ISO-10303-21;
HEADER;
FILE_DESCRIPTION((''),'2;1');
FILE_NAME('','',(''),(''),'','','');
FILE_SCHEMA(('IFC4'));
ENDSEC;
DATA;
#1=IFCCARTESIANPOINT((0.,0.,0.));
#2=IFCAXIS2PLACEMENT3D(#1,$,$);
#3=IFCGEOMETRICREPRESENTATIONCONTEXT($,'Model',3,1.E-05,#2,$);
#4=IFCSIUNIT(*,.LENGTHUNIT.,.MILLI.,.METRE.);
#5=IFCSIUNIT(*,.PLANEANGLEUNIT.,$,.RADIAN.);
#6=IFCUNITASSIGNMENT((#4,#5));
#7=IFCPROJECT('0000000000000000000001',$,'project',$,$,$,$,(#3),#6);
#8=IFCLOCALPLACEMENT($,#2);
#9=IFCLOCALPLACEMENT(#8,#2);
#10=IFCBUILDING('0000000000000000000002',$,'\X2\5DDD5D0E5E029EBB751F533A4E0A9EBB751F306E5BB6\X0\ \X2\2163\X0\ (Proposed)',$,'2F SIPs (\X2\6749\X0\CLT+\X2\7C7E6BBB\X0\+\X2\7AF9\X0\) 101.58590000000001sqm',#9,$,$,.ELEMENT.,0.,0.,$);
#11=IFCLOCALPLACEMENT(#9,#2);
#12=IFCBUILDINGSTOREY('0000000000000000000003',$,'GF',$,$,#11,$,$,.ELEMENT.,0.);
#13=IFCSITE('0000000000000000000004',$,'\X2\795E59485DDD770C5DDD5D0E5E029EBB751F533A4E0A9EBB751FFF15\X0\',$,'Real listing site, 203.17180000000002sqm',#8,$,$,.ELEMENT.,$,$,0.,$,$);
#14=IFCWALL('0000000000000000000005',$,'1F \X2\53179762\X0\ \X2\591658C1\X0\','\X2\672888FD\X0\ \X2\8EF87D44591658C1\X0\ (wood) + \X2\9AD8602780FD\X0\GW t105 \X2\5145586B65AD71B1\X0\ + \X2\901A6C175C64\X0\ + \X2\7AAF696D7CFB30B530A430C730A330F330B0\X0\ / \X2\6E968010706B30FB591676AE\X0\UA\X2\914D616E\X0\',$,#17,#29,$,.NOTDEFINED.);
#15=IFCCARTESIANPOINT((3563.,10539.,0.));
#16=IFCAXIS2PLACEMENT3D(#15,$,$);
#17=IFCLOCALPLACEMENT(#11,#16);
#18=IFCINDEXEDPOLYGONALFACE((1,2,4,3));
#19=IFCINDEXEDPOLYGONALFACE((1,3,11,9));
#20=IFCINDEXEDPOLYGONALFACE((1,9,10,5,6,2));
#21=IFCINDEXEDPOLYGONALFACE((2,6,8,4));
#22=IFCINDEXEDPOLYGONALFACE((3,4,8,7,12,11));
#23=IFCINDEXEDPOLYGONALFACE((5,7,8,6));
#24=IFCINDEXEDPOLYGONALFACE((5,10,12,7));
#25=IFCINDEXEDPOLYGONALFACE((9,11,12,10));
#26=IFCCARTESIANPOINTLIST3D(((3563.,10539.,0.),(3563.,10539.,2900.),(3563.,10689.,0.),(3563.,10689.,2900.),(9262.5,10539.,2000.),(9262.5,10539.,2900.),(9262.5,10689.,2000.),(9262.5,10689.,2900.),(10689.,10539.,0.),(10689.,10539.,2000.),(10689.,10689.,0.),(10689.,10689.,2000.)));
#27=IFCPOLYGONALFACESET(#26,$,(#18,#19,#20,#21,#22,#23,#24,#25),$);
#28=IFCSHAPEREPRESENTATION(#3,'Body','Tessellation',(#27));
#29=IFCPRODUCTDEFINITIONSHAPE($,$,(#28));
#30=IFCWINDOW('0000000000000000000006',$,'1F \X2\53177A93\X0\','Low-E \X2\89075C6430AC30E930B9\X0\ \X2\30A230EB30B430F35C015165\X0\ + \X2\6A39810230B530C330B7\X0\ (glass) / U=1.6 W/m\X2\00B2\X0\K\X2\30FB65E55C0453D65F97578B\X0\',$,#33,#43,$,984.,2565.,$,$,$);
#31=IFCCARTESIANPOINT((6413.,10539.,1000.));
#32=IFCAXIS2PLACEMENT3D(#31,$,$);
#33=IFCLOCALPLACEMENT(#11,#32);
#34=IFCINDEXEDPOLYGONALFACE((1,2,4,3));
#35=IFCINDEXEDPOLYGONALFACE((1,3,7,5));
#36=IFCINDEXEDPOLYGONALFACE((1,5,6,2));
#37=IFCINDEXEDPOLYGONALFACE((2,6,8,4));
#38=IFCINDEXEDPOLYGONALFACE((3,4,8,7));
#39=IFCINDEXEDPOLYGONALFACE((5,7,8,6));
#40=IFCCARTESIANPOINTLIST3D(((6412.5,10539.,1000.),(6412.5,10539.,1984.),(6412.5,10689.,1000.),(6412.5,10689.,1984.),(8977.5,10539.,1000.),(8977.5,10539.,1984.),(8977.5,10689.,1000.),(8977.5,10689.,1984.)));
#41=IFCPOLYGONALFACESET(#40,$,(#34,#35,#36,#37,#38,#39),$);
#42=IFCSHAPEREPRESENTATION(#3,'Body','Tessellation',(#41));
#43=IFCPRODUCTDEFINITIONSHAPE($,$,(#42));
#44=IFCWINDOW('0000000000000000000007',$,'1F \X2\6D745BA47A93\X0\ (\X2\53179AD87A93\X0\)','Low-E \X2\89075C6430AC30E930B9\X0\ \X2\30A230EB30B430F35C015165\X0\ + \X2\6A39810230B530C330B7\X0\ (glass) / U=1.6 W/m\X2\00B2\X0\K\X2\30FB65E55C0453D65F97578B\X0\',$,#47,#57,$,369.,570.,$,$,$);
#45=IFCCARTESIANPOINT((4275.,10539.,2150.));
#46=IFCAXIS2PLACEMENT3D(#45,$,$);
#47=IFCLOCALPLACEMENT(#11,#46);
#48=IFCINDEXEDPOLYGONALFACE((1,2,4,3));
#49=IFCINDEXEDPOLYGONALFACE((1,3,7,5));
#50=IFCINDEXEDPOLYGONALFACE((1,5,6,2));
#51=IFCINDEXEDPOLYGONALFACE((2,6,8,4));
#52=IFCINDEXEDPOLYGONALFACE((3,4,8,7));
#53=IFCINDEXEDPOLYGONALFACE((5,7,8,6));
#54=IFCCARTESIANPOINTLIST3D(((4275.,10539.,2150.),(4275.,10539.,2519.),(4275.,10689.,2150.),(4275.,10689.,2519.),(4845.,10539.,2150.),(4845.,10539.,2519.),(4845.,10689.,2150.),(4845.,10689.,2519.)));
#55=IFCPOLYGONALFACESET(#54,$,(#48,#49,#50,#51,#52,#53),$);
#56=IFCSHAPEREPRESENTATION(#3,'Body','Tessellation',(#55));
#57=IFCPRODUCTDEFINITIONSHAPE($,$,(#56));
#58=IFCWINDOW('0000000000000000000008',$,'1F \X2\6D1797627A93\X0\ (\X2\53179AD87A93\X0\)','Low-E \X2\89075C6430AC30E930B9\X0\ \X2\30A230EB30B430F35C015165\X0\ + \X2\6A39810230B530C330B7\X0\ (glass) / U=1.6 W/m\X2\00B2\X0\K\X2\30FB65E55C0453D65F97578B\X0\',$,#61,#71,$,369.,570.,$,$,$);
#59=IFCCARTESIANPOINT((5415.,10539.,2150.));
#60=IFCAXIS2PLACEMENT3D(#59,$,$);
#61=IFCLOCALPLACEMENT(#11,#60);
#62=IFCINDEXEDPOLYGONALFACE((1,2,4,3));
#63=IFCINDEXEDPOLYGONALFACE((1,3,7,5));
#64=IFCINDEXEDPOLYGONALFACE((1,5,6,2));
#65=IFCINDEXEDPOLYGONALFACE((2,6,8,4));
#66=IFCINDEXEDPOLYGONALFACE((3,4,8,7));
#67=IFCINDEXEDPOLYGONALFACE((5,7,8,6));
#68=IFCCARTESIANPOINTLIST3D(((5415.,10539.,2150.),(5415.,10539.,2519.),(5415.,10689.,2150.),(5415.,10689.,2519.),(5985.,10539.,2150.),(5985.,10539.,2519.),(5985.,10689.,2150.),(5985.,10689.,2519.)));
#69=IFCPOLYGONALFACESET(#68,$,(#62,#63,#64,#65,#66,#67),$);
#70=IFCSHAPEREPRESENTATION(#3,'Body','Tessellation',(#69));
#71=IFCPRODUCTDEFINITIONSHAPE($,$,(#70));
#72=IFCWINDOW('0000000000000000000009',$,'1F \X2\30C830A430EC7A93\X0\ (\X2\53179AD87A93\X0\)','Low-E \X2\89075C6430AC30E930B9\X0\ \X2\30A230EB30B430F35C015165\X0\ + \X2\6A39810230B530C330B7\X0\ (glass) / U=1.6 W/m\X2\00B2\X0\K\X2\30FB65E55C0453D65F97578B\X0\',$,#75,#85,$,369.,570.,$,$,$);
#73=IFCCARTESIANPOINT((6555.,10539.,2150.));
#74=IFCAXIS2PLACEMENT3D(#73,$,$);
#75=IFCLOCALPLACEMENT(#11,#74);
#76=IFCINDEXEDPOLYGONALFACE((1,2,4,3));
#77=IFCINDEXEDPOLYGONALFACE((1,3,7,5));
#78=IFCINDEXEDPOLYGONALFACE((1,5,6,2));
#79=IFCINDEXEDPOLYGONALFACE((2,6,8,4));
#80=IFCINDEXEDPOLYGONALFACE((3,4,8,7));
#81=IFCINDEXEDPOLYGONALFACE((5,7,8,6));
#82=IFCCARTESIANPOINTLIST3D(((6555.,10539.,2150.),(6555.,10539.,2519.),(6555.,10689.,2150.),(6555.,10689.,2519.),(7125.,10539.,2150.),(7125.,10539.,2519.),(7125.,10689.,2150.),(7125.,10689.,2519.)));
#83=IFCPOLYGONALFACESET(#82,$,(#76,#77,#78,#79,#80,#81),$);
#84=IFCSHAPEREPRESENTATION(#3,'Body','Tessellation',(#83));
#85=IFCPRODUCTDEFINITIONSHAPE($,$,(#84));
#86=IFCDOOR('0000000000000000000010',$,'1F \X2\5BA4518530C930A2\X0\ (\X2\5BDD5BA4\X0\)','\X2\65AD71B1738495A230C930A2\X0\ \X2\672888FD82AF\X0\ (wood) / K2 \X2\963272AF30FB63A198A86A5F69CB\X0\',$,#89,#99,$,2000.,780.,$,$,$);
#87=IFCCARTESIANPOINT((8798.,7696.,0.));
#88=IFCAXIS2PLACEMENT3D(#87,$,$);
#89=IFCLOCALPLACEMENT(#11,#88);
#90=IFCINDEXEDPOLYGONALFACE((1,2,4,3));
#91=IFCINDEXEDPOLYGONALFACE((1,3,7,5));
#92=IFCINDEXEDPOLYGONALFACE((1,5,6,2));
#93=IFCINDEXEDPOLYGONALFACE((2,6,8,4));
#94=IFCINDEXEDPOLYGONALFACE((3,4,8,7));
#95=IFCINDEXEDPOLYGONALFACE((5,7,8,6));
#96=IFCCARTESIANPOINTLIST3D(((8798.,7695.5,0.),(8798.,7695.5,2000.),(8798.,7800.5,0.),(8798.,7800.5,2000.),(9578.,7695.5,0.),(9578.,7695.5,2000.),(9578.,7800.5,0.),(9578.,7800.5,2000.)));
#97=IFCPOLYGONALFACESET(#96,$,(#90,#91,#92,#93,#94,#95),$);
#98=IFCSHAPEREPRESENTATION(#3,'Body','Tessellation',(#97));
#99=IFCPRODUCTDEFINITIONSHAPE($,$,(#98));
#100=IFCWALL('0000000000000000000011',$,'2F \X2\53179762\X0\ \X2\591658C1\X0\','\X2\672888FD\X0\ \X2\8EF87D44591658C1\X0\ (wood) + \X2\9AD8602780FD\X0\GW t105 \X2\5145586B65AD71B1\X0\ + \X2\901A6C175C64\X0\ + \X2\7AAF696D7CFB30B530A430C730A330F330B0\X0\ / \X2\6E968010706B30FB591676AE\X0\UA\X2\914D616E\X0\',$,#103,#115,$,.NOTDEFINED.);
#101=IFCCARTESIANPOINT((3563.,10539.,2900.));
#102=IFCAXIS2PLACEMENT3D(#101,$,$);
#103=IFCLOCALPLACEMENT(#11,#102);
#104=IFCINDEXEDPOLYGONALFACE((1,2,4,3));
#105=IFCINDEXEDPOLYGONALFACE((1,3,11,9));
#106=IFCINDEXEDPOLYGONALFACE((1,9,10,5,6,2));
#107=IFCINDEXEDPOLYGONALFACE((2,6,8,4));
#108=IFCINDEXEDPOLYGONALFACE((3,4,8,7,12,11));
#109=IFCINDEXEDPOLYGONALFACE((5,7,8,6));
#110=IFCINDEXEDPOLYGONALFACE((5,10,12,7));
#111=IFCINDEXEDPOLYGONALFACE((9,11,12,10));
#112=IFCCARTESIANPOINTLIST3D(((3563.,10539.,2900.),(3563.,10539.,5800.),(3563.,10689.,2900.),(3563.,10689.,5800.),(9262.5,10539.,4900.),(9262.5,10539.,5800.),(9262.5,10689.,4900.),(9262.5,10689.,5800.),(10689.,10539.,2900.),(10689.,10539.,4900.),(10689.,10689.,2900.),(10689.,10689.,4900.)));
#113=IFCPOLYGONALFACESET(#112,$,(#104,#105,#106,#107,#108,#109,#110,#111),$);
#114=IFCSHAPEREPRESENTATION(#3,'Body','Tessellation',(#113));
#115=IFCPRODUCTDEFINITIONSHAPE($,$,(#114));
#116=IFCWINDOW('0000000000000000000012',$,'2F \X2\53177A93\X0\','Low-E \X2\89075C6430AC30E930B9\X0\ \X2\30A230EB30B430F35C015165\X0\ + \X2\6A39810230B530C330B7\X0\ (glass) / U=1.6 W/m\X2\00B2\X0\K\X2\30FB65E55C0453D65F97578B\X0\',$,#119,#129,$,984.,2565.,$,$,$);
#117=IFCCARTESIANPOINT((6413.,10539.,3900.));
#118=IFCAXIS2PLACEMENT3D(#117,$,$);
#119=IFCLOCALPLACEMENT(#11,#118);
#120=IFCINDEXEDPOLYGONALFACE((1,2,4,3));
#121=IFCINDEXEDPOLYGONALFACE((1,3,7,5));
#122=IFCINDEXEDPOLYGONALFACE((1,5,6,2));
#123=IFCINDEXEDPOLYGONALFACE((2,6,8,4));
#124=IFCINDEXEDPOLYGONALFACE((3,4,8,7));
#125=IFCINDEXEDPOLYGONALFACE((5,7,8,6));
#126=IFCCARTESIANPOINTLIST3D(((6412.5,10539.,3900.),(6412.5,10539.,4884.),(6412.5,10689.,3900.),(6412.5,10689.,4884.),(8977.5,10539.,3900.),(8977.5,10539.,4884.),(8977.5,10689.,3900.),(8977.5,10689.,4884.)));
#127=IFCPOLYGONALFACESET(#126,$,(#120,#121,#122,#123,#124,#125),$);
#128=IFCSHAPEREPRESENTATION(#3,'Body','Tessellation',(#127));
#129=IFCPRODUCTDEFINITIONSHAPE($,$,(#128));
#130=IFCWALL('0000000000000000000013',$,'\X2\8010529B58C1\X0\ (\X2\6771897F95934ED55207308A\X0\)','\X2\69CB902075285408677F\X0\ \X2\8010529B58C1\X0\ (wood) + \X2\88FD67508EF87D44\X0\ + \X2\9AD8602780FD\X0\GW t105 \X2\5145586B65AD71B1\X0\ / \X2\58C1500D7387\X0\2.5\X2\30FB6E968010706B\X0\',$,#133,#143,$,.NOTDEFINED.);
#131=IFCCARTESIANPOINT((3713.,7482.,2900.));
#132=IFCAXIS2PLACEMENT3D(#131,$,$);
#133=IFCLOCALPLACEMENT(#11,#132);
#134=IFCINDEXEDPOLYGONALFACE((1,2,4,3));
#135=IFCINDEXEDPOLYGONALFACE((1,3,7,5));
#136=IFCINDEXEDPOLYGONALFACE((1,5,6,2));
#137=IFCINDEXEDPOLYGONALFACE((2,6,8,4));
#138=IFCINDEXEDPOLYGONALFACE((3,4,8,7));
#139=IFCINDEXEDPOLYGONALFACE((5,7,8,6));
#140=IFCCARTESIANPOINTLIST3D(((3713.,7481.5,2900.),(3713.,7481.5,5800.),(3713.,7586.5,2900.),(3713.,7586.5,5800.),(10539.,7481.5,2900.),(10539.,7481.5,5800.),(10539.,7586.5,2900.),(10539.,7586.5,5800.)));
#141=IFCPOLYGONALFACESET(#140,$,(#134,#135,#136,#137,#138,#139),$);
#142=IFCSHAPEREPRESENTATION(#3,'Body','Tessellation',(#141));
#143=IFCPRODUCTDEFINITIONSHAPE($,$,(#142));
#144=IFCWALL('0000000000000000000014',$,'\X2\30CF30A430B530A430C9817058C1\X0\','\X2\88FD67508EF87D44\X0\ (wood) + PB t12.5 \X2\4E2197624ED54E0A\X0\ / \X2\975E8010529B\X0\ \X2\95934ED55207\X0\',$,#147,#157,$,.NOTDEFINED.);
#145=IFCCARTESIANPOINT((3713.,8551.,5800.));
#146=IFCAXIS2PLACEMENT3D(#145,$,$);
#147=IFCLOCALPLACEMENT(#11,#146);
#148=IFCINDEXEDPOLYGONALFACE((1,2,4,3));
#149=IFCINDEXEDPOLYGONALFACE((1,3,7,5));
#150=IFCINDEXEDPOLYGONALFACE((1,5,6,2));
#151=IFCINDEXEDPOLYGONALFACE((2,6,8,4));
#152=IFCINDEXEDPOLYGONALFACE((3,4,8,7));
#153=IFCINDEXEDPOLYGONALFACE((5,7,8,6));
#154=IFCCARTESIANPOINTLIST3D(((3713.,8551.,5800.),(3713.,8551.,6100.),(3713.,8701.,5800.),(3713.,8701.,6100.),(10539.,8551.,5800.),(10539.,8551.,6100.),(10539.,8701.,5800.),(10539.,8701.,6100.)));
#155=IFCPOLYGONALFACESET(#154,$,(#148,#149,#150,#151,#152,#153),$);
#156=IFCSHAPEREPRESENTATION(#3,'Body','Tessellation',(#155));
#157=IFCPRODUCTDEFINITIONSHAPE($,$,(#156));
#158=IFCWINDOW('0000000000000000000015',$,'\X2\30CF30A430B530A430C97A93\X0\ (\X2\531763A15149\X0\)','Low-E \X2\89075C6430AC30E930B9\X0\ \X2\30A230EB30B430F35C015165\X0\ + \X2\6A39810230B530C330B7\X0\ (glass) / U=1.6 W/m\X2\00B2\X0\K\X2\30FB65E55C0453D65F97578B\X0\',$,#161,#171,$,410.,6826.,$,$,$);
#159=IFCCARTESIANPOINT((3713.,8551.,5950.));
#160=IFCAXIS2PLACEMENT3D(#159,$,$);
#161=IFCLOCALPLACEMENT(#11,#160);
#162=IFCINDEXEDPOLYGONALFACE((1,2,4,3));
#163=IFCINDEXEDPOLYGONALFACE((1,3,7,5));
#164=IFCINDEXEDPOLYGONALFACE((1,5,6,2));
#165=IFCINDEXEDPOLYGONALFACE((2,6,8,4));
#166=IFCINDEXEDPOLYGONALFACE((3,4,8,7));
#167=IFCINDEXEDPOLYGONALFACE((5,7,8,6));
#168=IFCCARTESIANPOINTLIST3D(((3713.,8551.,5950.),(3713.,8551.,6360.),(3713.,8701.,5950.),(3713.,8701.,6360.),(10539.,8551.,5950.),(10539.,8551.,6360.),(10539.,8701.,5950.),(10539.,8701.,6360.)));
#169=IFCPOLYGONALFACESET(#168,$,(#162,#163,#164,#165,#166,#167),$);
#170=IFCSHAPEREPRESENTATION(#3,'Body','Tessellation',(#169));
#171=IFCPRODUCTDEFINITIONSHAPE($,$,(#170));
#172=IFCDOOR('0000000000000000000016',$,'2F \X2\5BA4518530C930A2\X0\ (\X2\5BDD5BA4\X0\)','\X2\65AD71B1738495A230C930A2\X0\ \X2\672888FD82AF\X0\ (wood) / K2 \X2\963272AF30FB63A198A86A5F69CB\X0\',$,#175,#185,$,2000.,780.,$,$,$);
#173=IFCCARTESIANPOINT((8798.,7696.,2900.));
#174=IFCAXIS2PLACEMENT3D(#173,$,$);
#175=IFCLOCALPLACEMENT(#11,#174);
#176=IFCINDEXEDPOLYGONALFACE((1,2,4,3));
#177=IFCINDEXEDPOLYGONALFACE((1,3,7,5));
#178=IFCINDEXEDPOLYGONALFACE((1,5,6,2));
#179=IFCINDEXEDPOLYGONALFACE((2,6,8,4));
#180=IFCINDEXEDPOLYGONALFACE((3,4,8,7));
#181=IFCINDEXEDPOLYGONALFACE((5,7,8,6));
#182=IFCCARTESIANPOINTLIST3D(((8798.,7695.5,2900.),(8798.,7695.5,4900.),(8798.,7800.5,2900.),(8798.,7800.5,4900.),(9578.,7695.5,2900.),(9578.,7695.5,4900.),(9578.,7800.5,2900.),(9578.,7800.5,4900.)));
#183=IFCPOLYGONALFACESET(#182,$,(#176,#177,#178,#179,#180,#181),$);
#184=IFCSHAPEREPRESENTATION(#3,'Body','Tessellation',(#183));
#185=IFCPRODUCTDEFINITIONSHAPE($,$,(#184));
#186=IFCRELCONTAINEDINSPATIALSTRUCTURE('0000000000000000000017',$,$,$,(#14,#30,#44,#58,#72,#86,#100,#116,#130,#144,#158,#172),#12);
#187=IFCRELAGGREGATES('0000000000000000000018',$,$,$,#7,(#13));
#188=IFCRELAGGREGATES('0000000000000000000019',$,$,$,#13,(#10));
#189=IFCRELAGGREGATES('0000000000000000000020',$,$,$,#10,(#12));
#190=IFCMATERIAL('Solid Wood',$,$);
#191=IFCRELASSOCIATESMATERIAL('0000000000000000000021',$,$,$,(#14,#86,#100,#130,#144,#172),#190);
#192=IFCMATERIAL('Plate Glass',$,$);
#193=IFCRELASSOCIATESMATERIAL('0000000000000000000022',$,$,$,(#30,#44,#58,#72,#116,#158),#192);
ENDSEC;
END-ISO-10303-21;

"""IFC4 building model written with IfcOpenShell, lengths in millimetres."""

from ifc_helpers import new_model, si_unit, frame, frame_2d, origin, place, context, project, spatial, rectangle, extrude, material, element, fill, save


model = new_model("IFC4")

# Units and contexts
model_context = context("Model", 3, precision=1e-05, world=origin())
ifc_project = project(units=[si_unit("LENGTHUNIT", "METRE", prefix="MILLI"), si_unit("PLANEANGLEUNIT", "RADIAN")], contexts=[model_context])

# Site, building, storey
site_placement = place(None, origin())
site = spatial("IfcSite", under=ifc_project, at=site_placement, Name="神奈川県川崎市麻生区上麻生５", ObjectType="Real listing site, 203.17180000000002sqm", CompositionType="ELEMENT", RefElevation=0.0)
building_placement = place(site_placement, origin())
building = spatial("IfcBuilding", under=site, at=building_placement, Name="川崎市麻生区上麻生の家 Ⅳ (Proposed)", ObjectType="2F SIPs (杉CLT+籾殻+竹) 101.58590000000001sqm", CompositionType="ELEMENT", ElevationOfRefHeight=0.0, ElevationOfTerrain=0.0)
storey_placement = place(building_placement, origin())
storey = spatial("IfcBuildingStorey", under=building, at=storey_placement, Name="GF", CompositionType="ELEMENT", Elevation=0.0)

# Wall, openings, windows
ifc_material_1 = material(Name="Solid Wood")
wall_1_placement = place(storey_placement, frame((3563.0, 10539.0, 0.0)))
wall_1 = element("IfcWall", 1, at=wall_1_placement, inside=storey, material=ifc_material_1, Name="1F 北面 外壁", Description="木製 軸組外壁 (wood) + 高性能GW t105 充填断熱 + 通気層 + 窯業系サイディング / 準耐火・外皮UA配慮", PredefinedType="NOTDEFINED", context=model_context, shape_type="SweptSolid", body=[
    extrude(rectangle(XDim=7126.0, YDim=150.0, at=frame_2d((3563.0, 75.0))), frame((3563.0, 10539.0, 0.0)), (0.0, 0.0, 1.0), 2900.0),
])
opening_1_placement = place(storey_placement, frame((6413.0, 10539.0, 1000.0)))
opening_1 = element("IfcOpeningElement", 2, at=opening_1_placement, cuts=wall_1, PredefinedType="NOTDEFINED", context=model_context, shape_type="SweptSolid", body=[
    extrude(rectangle(XDim=2565.0, YDim=150.0, at=frame_2d((1282.0, 75.0))), frame((6413.0, 10539.0, 1000.0)), (0.0, 0.0, 1.0), 984.0),
])
opening_2_placement = place(storey_placement, frame((4275.0, 10539.0, 2150.0)))
opening_2 = element("IfcOpeningElement", 3, at=opening_2_placement, cuts=wall_1, PredefinedType="NOTDEFINED", context=model_context, shape_type="SweptSolid", body=[
    extrude(rectangle(XDim=570.0, YDim=150.0, at=frame_2d((285.0, 75.0))), frame((4275.0, 10539.0, 2150.0)), (0.0, 0.0, 1.0), 369.0),
])
opening_3_placement = place(storey_placement, frame((5415.0, 10539.0, 2150.0)))
opening_3 = element("IfcOpeningElement", 4, at=opening_3_placement, cuts=wall_1, PredefinedType="NOTDEFINED", context=model_context, shape_type="SweptSolid", body=[
    extrude(rectangle(XDim=570.0, YDim=150.0, at=frame_2d((285.0, 75.0))), frame((5415.0, 10539.0, 2150.0)), (0.0, 0.0, 1.0), 369.0),
])
opening_4_placement = place(storey_placement, frame((6555.0, 10539.0, 2150.0)))
opening_4 = element("IfcOpeningElement", 5, at=opening_4_placement, cuts=wall_1, PredefinedType="NOTDEFINED", context=model_context, shape_type="SweptSolid", body=[
    extrude(rectangle(XDim=570.0, YDim=150.0, at=frame_2d((285.0, 75.0))), frame((6555.0, 10539.0, 2150.0)), (0.0, 0.0, 1.0), 369.0),
])
ifc_material_2 = material(Name="Plate Glass")
window_1_placement = place(storey_placement, frame((6413.0, 10539.0, 1000.0)))
window_1 = element("IfcWindow", 6, at=window_1_placement, inside=storey, material=ifc_material_2, Name="1F 北窓", Description="Low-E 複層ガラス アルゴン封入 + 樹脂サッシ (glass) / U=1.6 W/m²K・日射取得型", OverallHeight=984.0, OverallWidth=2565.0, context=model_context, shape_type="SweptSolid", body=[
    extrude(rectangle(XDim=2565.0, YDim=150.0, at=frame_2d((1282.0, 75.0))), frame((6413.0, 10539.0, 1000.0)), (0.0, 0.0, 1.0), 984.0),
])
fill(opening_1, window_1)
window_2_placement = place(storey_placement, frame((4275.0, 10539.0, 2150.0)))
window_2 = element("IfcWindow", 7, at=window_2_placement, inside=storey, material=ifc_material_2, Name="1F 浴室窓 (北高窓)", Description="Low-E 複層ガラス アルゴン封入 + 樹脂サッシ (glass) / U=1.6 W/m²K・日射取得型", OverallHeight=369.0, OverallWidth=570.0, context=model_context, shape_type="SweptSolid", body=[
    extrude(rectangle(XDim=570.0, YDim=150.0, at=frame_2d((285.0, 75.0))), frame((4275.0, 10539.0, 2150.0)), (0.0, 0.0, 1.0), 369.0),
])
fill(opening_2, window_2)
window_3_placement = place(storey_placement, frame((5415.0, 10539.0, 2150.0)))
window_3 = element("IfcWindow", 8, at=window_3_placement, inside=storey, material=ifc_material_2, Name="1F 洗面窓 (北高窓)", Description="Low-E 複層ガラス アルゴン封入 + 樹脂サッシ (glass) / U=1.6 W/m²K・日射取得型", OverallHeight=369.0, OverallWidth=570.0, context=model_context, shape_type="SweptSolid", body=[
    extrude(rectangle(XDim=570.0, YDim=150.0, at=frame_2d((285.0, 75.0))), frame((5415.0, 10539.0, 2150.0)), (0.0, 0.0, 1.0), 369.0),
])
fill(opening_3, window_3)
window_4_placement = place(storey_placement, frame((6555.0, 10539.0, 2150.0)))
window_4 = element("IfcWindow", 9, at=window_4_placement, inside=storey, material=ifc_material_2, Name="1F トイレ窓 (北高窓)", Description="Low-E 複層ガラス アルゴン封入 + 樹脂サッシ (glass) / U=1.6 W/m²K・日射取得型", OverallHeight=369.0, OverallWidth=570.0, context=model_context, shape_type="SweptSolid", body=[
    extrude(rectangle(XDim=570.0, YDim=150.0, at=frame_2d((285.0, 75.0))), frame((6555.0, 10539.0, 2150.0)), (0.0, 0.0, 1.0), 369.0),
])
fill(opening_4, window_4)

# Door
door_1_placement = place(storey_placement, frame((8798.0, 7696.0, 0.0)))
element("IfcDoor", 10, at=door_1_placement, inside=storey, material=ifc_material_1, Name="1F 室内ドア (寝室)", Description="断熱玄関ドア 木製芯 (wood) / K2 防犯・採風機構", OverallHeight=2000.0, OverallWidth=780.0, context=model_context, shape_type="SweptSolid", body=[
    extrude(rectangle(XDim=780.0, YDim=105.0, at=frame_2d((390.0, 52.0))), frame((8798.0, 7696.0, 0.0)), (0.0, 0.0, 1.0), 2000.0),
])

# Wall, opening, window
wall_2_placement = place(storey_placement, frame((3563.0, 10539.0, 2900.0)))
wall_2 = element("IfcWall", 11, at=wall_2_placement, inside=storey, material=ifc_material_1, Name="2F 北面 外壁", Description="木製 軸組外壁 (wood) + 高性能GW t105 充填断熱 + 通気層 + 窯業系サイディング / 準耐火・外皮UA配慮", PredefinedType="NOTDEFINED", context=model_context, shape_type="SweptSolid", body=[
    extrude(rectangle(XDim=7126.0, YDim=150.0, at=frame_2d((3563.0, 75.0))), frame((3563.0, 10539.0, 2900.0)), (0.0, 0.0, 1.0), 2900.0),
])
opening_5_placement = place(storey_placement, frame((6413.0, 10539.0, 3900.0)))
opening_5 = element("IfcOpeningElement", 12, at=opening_5_placement, cuts=wall_2, PredefinedType="NOTDEFINED", context=model_context, shape_type="SweptSolid", body=[
    extrude(rectangle(XDim=2565.0, YDim=150.0, at=frame_2d((1282.0, 75.0))), frame((6413.0, 10539.0, 3900.0)), (0.0, 0.0, 1.0), 984.0),
])
window_5_placement = place(storey_placement, frame((6413.0, 10539.0, 3900.0)))
window_5 = element("IfcWindow", 13, at=window_5_placement, inside=storey, material=ifc_material_2, Name="2F 北窓", Description="Low-E 複層ガラス アルゴン封入 + 樹脂サッシ (glass) / U=1.6 W/m²K・日射取得型", OverallHeight=984.0, OverallWidth=2565.0, context=model_context, shape_type="SweptSolid", body=[
    extrude(rectangle(XDim=2565.0, YDim=150.0, at=frame_2d((1282.0, 75.0))), frame((6413.0, 10539.0, 3900.0)), (0.0, 0.0, 1.0), 984.0),
])
fill(opening_5, window_5)

# Wall
wall_3_placement = place(storey_placement, frame((3713.0, 7482.0, 2900.0)))
element("IfcWall", 14, at=wall_3_placement, inside=storey, material=ifc_material_1, Name="耐力壁 (東西間仕切り)", Description="構造用合板 耐力壁 (wood) + 製材軸組 + 高性能GW t105 充填断熱 / 壁倍率2.5・準耐火", PredefinedType="NOTDEFINED", context=model_context, shape_type="SweptSolid", body=[
    extrude(rectangle(XDim=6826.0, YDim=105.0, at=frame_2d((3413.0, 52.0))), frame((3713.0, 7482.0, 2900.0)), (0.0, 0.0, 1.0), 2900.0),
])

# Wall, opening, window
wall_4_placement = place(storey_placement, frame((3713.0, 8551.0, 5800.0)))
wall_4 = element("IfcWall", 15, at=wall_4_placement, inside=storey, material=ifc_material_1, Name="ハイサイド腰壁", Description="製材軸組 (wood) + PB t12.5 両面仕上 / 非耐力 間仕切", PredefinedType="NOTDEFINED", context=model_context, shape_type="SweptSolid", body=[
    extrude(rectangle(XDim=6826.0, YDim=150.0, at=frame_2d((3413.0, 75.0))), frame((3713.0, 8551.0, 5800.0)), (0.0, 0.0, 1.0), 700.0),
])
opening_6_placement = place(storey_placement, frame((3713.0, 8551.0, 5950.0)))
opening_6 = element("IfcOpeningElement", 16, at=opening_6_placement, cuts=wall_4, PredefinedType="NOTDEFINED", context=model_context, shape_type="SweptSolid", body=[
    extrude(rectangle(XDim=6826.0, YDim=150.0, at=frame_2d((3413.0, 75.0))), frame((3713.0, 8551.0, 5950.0)), (0.0, 0.0, 1.0), 410.0),
])
window_6_placement = place(storey_placement, frame((3713.0, 8551.0, 5950.0)))
window_6 = element("IfcWindow", 17, at=window_6_placement, inside=storey, material=ifc_material_2, Name="ハイサイド窓 (北採光)", Description="Low-E 複層ガラス アルゴン封入 + 樹脂サッシ (glass) / U=1.6 W/m²K・日射取得型", OverallHeight=410.0, OverallWidth=6826.0, context=model_context, shape_type="SweptSolid", body=[
    extrude(rectangle(XDim=6826.0, YDim=150.0, at=frame_2d((3413.0, 75.0))), frame((3713.0, 8551.0, 5950.0)), (0.0, 0.0, 1.0), 410.0),
])
fill(opening_6, window_6)

# Door
door_2_placement = place(storey_placement, frame((8798.0, 7696.0, 2900.0)))
element("IfcDoor", 18, at=door_2_placement, inside=storey, material=ifc_material_1, Name="2F 室内ドア (寝室)", Description="断熱玄関ドア 木製芯 (wood) / K2 防犯・採風機構", OverallHeight=2000.0, OverallWidth=780.0, context=model_context, shape_type="SweptSolid", body=[
    extrude(rectangle(XDim=780.0, YDim=105.0, at=frame_2d((390.0, 52.0))), frame((8798.0, 7696.0, 2900.0)), (0.0, 0.0, 1.0), 2000.0),
])

save(model, "model.ifc")
